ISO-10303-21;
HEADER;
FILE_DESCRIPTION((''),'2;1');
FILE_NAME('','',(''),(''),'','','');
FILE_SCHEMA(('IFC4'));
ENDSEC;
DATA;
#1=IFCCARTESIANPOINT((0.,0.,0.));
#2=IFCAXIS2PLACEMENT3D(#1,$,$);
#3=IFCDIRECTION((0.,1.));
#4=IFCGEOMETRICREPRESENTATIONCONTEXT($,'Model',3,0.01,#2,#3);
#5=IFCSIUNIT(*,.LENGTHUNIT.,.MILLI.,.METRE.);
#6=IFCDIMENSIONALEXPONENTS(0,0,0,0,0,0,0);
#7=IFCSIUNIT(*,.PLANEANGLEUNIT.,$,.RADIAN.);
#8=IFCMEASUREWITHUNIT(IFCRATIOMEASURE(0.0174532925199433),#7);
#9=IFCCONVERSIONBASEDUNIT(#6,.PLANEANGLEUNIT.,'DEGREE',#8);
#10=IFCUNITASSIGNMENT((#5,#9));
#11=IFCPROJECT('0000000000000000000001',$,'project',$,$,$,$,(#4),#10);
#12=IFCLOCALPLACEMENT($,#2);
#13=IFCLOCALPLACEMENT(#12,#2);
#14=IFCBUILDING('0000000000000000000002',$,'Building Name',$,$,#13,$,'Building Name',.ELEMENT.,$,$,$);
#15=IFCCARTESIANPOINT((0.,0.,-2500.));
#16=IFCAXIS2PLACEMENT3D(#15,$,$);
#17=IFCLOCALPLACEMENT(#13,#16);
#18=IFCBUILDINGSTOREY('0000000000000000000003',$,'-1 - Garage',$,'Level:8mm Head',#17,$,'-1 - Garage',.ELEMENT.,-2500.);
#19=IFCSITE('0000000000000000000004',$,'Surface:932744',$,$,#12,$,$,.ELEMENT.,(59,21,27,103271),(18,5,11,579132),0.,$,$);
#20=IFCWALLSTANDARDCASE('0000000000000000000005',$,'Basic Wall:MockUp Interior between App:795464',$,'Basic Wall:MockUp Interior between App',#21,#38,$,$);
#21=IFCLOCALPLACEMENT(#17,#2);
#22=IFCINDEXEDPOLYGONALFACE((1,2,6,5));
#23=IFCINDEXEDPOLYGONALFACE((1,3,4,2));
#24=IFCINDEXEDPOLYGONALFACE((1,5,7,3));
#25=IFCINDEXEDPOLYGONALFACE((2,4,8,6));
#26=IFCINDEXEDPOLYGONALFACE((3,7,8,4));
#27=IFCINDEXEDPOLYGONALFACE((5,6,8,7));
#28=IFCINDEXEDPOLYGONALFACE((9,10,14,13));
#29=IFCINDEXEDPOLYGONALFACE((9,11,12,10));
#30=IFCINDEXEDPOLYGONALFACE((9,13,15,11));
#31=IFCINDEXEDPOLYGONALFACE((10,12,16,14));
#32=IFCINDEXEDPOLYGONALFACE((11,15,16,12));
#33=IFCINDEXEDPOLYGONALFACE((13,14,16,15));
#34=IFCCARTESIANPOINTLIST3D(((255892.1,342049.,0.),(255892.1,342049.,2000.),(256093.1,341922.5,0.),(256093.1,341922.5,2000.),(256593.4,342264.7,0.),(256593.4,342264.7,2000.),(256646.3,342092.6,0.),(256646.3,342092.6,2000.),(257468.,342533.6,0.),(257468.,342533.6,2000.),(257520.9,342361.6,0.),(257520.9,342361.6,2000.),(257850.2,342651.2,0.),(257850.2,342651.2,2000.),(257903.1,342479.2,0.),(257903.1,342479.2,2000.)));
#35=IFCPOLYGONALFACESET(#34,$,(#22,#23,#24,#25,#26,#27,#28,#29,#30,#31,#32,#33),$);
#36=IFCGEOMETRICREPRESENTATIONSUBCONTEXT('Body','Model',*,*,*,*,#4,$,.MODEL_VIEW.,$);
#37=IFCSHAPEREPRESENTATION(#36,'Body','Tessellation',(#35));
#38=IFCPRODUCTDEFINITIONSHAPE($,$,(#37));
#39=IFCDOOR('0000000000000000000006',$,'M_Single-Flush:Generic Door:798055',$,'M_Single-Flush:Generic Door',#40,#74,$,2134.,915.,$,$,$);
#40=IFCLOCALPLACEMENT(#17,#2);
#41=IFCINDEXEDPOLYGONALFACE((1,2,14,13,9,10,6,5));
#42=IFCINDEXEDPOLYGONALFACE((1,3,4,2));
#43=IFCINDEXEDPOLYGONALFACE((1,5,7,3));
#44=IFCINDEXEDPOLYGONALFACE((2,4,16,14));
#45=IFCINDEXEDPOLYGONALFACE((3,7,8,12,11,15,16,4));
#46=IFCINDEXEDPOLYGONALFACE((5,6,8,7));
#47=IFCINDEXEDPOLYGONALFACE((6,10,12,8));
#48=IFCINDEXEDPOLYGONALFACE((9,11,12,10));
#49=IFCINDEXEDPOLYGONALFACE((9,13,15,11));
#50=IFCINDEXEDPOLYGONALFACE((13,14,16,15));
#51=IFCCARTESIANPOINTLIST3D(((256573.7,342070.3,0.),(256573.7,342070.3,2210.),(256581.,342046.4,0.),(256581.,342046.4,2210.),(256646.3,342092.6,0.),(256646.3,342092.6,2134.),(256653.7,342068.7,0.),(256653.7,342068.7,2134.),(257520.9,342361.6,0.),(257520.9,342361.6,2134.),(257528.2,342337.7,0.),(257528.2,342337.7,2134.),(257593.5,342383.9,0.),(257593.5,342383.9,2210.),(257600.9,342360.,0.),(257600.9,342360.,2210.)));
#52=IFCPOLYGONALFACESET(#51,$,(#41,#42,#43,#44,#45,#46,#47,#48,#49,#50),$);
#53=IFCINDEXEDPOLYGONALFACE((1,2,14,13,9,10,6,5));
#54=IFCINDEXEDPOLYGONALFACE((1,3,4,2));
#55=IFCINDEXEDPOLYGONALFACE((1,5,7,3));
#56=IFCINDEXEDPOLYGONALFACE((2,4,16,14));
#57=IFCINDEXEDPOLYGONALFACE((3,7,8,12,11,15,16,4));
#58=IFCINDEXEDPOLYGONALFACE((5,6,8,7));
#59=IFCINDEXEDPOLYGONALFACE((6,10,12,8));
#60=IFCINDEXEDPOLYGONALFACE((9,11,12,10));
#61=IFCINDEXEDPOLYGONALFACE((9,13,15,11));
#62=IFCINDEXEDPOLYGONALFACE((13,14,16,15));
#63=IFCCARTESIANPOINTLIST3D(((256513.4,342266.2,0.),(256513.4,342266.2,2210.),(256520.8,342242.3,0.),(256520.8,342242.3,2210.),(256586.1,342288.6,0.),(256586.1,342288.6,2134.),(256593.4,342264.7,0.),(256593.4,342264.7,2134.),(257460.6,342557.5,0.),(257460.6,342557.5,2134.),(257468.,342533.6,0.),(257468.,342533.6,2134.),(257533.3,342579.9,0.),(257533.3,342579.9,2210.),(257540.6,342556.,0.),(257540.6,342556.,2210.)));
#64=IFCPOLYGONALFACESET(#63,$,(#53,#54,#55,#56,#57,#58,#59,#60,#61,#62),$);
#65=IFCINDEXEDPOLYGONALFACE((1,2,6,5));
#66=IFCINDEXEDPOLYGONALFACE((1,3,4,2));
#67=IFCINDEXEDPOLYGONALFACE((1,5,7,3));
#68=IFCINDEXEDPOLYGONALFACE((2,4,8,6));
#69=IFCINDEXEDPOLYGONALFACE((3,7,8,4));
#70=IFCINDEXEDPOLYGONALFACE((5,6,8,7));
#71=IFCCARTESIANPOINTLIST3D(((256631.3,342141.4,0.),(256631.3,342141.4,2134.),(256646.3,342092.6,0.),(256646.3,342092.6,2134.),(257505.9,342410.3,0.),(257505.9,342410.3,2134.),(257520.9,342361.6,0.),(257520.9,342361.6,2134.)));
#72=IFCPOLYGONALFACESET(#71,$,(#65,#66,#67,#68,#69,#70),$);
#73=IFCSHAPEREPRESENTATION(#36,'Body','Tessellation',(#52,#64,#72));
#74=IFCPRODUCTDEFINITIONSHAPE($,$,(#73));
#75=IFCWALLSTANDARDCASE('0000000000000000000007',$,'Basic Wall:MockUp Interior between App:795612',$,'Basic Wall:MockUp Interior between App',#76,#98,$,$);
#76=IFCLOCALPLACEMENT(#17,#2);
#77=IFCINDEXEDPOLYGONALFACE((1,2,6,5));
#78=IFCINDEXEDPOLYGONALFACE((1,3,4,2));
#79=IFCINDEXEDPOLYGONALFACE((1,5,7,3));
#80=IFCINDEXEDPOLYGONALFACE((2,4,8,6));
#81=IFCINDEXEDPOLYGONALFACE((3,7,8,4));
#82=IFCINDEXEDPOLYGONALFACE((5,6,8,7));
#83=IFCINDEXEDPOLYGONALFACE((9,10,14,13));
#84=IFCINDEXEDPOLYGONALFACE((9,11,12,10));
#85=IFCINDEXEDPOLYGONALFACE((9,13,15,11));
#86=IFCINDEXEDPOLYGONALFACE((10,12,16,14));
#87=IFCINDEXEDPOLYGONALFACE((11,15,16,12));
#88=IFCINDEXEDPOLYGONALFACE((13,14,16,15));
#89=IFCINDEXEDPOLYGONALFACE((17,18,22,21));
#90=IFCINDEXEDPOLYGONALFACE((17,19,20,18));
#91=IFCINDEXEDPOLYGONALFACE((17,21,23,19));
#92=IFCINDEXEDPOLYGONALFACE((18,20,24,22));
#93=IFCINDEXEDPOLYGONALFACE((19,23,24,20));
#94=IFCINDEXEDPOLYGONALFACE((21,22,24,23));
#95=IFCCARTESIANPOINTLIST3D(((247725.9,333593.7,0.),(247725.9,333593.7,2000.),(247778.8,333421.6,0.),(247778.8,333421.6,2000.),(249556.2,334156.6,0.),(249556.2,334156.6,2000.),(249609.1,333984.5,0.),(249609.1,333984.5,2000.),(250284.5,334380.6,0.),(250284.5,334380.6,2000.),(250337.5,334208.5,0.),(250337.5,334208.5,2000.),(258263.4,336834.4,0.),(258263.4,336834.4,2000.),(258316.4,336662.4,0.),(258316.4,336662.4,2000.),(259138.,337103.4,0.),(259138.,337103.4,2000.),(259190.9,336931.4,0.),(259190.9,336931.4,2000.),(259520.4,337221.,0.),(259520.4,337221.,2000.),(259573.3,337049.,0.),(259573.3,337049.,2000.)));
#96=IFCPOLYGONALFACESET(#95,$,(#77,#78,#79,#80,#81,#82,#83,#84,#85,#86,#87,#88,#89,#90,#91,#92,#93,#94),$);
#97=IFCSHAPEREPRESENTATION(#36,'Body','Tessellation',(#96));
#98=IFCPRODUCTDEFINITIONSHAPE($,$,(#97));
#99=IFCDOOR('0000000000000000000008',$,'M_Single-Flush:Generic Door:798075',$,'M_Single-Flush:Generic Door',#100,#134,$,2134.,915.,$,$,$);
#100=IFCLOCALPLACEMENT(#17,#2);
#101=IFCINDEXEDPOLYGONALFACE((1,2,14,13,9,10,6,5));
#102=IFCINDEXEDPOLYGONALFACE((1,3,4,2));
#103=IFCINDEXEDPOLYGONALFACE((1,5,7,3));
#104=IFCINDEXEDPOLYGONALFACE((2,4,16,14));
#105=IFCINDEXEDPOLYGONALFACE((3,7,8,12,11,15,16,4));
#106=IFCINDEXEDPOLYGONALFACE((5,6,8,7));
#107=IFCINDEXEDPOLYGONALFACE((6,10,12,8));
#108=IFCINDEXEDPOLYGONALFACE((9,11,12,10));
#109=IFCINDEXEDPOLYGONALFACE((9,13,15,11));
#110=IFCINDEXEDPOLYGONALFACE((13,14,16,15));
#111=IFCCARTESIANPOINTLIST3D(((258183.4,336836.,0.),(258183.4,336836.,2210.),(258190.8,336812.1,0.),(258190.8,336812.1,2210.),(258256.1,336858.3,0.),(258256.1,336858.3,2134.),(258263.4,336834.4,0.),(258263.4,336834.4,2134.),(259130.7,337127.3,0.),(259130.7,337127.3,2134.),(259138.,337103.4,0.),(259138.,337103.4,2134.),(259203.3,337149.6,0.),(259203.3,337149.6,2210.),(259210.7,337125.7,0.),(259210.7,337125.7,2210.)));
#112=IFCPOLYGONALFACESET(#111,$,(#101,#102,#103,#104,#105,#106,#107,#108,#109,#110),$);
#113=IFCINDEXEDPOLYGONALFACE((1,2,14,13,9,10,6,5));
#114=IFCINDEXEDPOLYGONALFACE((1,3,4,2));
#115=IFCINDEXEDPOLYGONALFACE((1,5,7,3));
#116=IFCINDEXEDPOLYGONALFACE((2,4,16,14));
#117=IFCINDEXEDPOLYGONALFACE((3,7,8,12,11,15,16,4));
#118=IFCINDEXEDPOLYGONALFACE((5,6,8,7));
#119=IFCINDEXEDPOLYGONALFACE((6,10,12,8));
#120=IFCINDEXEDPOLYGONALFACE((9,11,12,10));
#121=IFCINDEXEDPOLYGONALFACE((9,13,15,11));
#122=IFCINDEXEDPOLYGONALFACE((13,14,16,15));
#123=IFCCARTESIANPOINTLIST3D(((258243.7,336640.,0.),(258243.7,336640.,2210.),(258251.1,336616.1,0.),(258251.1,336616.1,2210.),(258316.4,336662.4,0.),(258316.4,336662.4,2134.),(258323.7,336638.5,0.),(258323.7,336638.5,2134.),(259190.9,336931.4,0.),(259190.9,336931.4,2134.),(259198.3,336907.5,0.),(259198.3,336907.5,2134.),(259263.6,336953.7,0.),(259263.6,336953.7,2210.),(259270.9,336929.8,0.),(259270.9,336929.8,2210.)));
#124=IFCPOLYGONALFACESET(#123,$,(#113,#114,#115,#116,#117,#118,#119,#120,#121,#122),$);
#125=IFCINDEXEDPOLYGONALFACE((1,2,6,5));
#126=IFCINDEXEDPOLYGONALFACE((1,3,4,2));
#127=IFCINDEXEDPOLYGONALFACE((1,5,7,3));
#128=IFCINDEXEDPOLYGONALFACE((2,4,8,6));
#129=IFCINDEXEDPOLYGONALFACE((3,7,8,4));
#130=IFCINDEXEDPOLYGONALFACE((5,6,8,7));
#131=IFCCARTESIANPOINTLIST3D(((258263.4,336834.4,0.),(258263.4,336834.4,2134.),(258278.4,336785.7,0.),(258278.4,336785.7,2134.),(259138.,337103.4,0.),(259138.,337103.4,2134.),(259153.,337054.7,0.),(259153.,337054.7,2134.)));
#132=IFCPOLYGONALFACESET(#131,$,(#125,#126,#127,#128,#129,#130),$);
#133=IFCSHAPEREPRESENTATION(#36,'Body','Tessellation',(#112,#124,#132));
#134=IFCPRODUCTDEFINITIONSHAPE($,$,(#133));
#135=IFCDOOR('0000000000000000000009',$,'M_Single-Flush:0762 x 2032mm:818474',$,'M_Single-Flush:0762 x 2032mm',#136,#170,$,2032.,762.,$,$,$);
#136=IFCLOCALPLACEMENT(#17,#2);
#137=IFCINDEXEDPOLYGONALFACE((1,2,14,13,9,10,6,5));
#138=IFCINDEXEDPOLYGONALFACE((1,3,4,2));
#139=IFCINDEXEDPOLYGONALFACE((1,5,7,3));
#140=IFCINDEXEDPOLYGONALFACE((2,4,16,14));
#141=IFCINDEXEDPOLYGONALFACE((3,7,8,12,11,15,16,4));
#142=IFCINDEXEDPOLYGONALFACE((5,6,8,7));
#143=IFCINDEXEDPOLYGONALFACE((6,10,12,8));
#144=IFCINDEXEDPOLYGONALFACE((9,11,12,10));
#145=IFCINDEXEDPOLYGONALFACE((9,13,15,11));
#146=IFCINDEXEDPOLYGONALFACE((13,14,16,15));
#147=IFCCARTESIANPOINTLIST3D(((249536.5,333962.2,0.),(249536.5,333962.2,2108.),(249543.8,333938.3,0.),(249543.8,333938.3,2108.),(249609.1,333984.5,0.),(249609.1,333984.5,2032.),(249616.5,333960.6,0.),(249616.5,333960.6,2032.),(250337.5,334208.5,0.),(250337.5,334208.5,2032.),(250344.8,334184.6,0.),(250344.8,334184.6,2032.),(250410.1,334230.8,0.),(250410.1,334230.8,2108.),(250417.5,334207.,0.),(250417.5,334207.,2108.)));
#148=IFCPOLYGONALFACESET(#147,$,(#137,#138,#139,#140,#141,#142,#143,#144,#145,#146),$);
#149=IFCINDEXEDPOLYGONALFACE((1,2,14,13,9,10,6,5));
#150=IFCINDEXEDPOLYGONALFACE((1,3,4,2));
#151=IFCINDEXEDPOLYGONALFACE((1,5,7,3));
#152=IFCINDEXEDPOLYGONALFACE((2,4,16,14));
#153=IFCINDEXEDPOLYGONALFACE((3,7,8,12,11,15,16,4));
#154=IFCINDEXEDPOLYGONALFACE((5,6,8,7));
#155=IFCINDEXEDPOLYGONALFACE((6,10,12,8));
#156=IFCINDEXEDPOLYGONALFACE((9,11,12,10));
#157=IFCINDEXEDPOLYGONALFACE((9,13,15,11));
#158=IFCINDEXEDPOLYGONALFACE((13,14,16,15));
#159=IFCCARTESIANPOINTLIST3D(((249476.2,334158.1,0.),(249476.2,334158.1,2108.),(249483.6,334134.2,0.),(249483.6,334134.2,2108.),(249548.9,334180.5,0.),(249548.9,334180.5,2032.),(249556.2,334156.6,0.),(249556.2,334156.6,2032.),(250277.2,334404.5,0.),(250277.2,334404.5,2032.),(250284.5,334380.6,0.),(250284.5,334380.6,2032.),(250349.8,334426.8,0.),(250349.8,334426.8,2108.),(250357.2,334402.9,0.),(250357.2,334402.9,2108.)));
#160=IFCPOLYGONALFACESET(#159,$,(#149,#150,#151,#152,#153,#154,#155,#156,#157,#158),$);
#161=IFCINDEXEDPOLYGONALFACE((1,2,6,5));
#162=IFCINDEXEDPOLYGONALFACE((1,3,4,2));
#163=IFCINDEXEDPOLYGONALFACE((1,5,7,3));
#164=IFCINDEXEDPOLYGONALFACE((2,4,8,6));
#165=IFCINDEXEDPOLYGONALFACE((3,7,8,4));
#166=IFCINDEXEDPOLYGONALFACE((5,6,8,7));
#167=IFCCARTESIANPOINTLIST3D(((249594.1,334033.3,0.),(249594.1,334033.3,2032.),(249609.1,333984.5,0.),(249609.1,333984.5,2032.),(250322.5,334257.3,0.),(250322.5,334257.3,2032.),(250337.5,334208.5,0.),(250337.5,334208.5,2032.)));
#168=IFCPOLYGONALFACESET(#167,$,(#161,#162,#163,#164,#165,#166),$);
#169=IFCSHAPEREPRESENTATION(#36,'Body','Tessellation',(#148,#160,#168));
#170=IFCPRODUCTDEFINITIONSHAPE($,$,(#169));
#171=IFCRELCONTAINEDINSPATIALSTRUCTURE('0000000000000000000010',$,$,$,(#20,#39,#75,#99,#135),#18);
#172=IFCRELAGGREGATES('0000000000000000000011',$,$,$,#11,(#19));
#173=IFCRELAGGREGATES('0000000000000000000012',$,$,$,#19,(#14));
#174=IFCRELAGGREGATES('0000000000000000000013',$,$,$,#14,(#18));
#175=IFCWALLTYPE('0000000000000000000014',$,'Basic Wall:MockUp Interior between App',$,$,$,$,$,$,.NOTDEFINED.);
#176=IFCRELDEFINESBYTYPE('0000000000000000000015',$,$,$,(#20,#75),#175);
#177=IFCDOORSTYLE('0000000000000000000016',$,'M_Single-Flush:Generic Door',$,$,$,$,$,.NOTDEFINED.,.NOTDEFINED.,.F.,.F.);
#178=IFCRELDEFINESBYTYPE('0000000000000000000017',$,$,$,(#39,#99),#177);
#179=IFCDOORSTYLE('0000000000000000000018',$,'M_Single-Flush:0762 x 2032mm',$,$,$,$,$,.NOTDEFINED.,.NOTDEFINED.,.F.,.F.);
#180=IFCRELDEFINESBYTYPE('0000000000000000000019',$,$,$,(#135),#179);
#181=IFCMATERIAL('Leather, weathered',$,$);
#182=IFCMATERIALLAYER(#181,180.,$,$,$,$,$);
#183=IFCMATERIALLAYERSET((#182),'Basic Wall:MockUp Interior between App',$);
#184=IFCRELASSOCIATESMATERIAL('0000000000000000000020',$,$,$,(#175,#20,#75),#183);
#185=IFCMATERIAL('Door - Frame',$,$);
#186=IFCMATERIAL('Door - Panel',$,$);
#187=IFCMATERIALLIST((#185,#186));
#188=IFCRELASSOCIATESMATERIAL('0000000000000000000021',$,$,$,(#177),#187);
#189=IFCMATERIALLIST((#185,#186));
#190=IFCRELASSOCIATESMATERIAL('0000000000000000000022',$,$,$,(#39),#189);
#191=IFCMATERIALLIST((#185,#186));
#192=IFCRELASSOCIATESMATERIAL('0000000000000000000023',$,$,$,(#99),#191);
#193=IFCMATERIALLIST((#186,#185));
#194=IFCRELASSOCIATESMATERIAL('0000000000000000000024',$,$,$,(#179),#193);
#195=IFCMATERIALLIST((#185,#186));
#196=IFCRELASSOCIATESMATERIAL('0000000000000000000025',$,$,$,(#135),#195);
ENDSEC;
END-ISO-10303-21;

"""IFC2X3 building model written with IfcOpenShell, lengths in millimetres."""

from ifc_helpers import new_model, entity, si_unit, converted_unit, direction, frame, frame_2d, origin, place, context, subcontext, project, spatial, polyline, rectangle, outline, extrude, source, transform, mapped, material, material_list, layer, layer_set, layer_usage, type_object, type_shapes, element, fill, save


model = new_model("IFC2X3")

# Units and contexts
model_context = context("Model", 3, precision=0.01, world=origin(), true_north=direction((0.0, 1.0)))
body_context = subcontext(model_context, "Body", "Model", "MODEL_VIEW")
ifc_project = project(units=[si_unit("LENGTHUNIT", "METRE", prefix="MILLI"), converted_unit("PLANEANGLEUNIT", "DEGREE", entity("IfcRatioMeasure", 0.0174532925199433), si_unit("PLANEANGLEUNIT", "RADIAN"), dimensions=[0, 0, 0, 0, 0, 0, 0])], contexts=[model_context])

# Site, building, storey
site_placement = place(None, origin())
site = spatial("IfcSite", under=ifc_project, at=site_placement, Name="Surface:932744", CompositionType="ELEMENT", RefLatitude=(59, 21, 27, 103271), RefLongitude=(18, 5, 11, 579132), RefElevation=0.0)
building_placement = place(site_placement, origin())
building = spatial("IfcBuilding", under=site, at=building_placement, Name="Building Name", LongName="Building Name", CompositionType="ELEMENT")
storey_placement = place(building_placement, frame((0.0, 0.0, -2500.0)))
storey = spatial("IfcBuildingStorey", under=building, at=storey_placement, Name="-1 - Garage", ObjectType="Level:8mm Head", LongName="-1 - Garage", CompositionType="ELEMENT", Elevation=-2500.0)

# Wall, opening, door
ifc_material_1 = material(Name="Leather, weathered")
ifc_layer_1 = layer(ifc_material_1, 180.0)
ifc_layer_set_1 = layer_set([ifc_layer_1], Name="Basic Wall:MockUp Interior between App")
ifc_layer_usage_1 = layer_usage(ifc_layer_set_1, "AXIS2", "NEGATIVE", 90.0)
wall_type_1 = type_object("IfcWallType", Name="Basic Wall:MockUp Interior between App", PredefinedType="NOTDEFINED", material=ifc_layer_set_1)
wall_1_placement = place(storey_placement, frame((257876.7, 342565.2, 0.0), z_axis=(0.0, 0.0, 1.0), x_axis=(-0.955818, -0.293958, 0.0)))
wall_1 = element("IfcWallStandardCase", 1, at=wall_1_placement, inside=storey, type_object=wall_type_1, material=ifc_layer_usage_1, Name="Basic Wall:MockUp Interior between App:795464", ObjectType="Basic Wall:MockUp Interior between App", context=body_context, shape_type="SweptSolid", body=[
    extrude(outline(polyline([(0.0, 90.0), (0.0, -90.0), (2048.7, -90.0), (1893.7, 90.0), (0.0, 90.0)])), origin(), (0.0, 0.0, 1.0), 2000.0),
])
opening_1_placement = place(wall_1_placement, frame((399.9, -90.0, 0.0)))
opening_1 = element("IfcOpeningElement", 2, at=opening_1_placement, cuts=wall_1, ObjectType="Opening", context=body_context, shape_type="SweptSolid", body=[
    extrude(rectangle(XDim=915.0, YDim=2134.0, at=frame_2d((1067.0, 457.5), x_axis=(0.0, 1.0))), frame((0.0, 0.0, 0.0), z_axis=(0.0, 1.0, 0.0), x_axis=(0.0, 0.0, 1.0)), (0.0, 0.0, 1.0), 180.0),
])
ifc_material_2 = material(Name="Door - Frame")
ifc_material_3 = material(Name="Door - Panel")
ifc_material_list_1 = material_list([ifc_material_2, ifc_material_3])
ifc_material_list_2 = material_list([ifc_material_2, ifc_material_3])
door_style_1 = type_object("IfcDoorStyle", Name="M_Single-Flush:Generic Door", ConstructionType="NOTDEFINED", OperationType="NOTDEFINED", ParameterTakesPrecedence=False, Sizeable=False, material=ifc_material_list_2)
shared_shape_1 = source(origin(), body_context, "Body", "SweptSolid", [
    extrude(outline(polyline([(-533.5, -1124.0), (533.5, -1124.0), (533.5, 1086.0), (457.5, 1086.0), (457.5, -1048.0), (-457.5, -1048.0), (-457.5, 1086.0), (-533.5, 1086.0), (-533.5, -1124.0)])), frame((457.5, 180.0, 1086.0), z_axis=(0.0, 1.0, 0.0), x_axis=(1.0, 0.0, 0.0)), (0.0, 0.0, 1.0), 25.0),
    extrude(outline(polyline([(-1124.0, -533.5), (1086.0, -533.5), (1086.0, -457.5), (-1048.0, -457.5), (-1048.0, 457.5), (1086.0, 457.5), (1086.0, 533.5), (-1124.0, 533.5), (-1124.0, -533.5)])), frame((457.5, -25.0, 1086.0), z_axis=(0.0, 1.0, 0.0), x_axis=(0.0, 0.0, -1.0)), (0.0, 0.0, 1.0), 25.0),
    extrude(rectangle(XDim=51.0, YDim=915.0, at=frame_2d((0.0, 0.0), x_axis=(1.0, 0.0))), frame((457.5, 154.5, 0.0), z_axis=(0.0, 0.0, 1.0), x_axis=(0.0, 1.0, 0.0)), (0.0, 0.0, 1.0), 2134.0),
])
type_shapes(door_style_1, [shared_shape_1])
door_1_placement = place(opening_1_placement, origin())
door_1 = element("IfcDoor", 3, at=door_1_placement, inside=storey, type_object=door_style_1, material=ifc_material_list_1, Name="M_Single-Flush:Generic Door:798055", ObjectType="M_Single-Flush:Generic Door", OverallHeight=2134.0, OverallWidth=915.0, context=body_context, shape_type="MappedRepresentation", body=[
    mapped(shared_shape_1, transform((0.0, 0.0, 0.0), scale=1.0)),
])
fill(opening_1, door_1)

# Wall, openings, doors
ifc_layer_usage_2 = layer_usage(ifc_layer_set_1, "AXIS2", "NEGATIVE", 90.0)
wall_2_placement = place(storey_placement, frame((259546.9, 337135.0, 0.0), z_axis=(0.0, 0.0, 1.0), x_axis=(-0.955818, -0.293958, 0.0)))
wall_2 = element("IfcWallStandardCase", 4, at=wall_2_placement, inside=storey, type_object=wall_type_1, material=ifc_layer_usage_2, Name="Basic Wall:MockUp Interior between App:795612", ObjectType="Basic Wall:MockUp Interior between App", context=body_context, shape_type="SweptSolid", body=[
    extrude(rectangle(XDim=12339.7, YDim=180.0, at=frame_2d((6169.8, 0.0), x_axis=(-1.0, 0.0))), origin(), (0.0, 0.0, 1.0), 2000.0),
])
opening_2_placement = place(wall_2_placement, frame((1315.1, 90.0, 0.0)))
opening_2 = element("IfcOpeningElement", 5, at=opening_2_placement, cuts=wall_2, ObjectType="Opening", context=body_context, shape_type="SweptSolid", body=[
    extrude(rectangle(XDim=915.0, YDim=2134.0, at=frame_2d((1067.0, 457.5), x_axis=(0.0, 1.0))), frame((0.0, 0.0, 0.0), z_axis=(0.0, -1.0, 0.0), x_axis=(0.0, 0.0, 1.0)), (0.0, 0.0, 1.0), 180.0),
])
opening_3_placement = place(wall_2_placement, frame((9662.8, -90.0, 0.0)))
opening_3 = element("IfcOpeningElement", 6, at=opening_3_placement, cuts=wall_2, ObjectType="Opening", context=body_context, shape_type="SweptSolid", body=[
    extrude(rectangle(XDim=762.0, YDim=2032.0, at=frame_2d((1016.0, 381.0), x_axis=(0.0, 1.0))), frame((0.0, 0.0, 0.0), z_axis=(0.0, 1.0, 0.0), x_axis=(0.0, 0.0, 1.0)), (0.0, 0.0, 1.0), 180.0),
])
ifc_material_list_3 = material_list([ifc_material_2, ifc_material_3])
door_2_placement = place(opening_2_placement, frame((0.0, 0.0, 0.0), z_axis=(0.0, 0.0, 1.0), x_axis=(-1.0, 0.0, 0.0)))
door_2 = element("IfcDoor", 7, at=door_2_placement, inside=storey, type_object=door_style_1, material=ifc_material_list_3, Name="M_Single-Flush:Generic Door:798075", ObjectType="M_Single-Flush:Generic Door", OverallHeight=2134.0, OverallWidth=915.0, context=body_context, shape_type="MappedRepresentation", body=[
    mapped(shared_shape_1, transform((0.0, 0.0, 0.0), scale=1.0)),
])
fill(opening_2, door_2)
ifc_material_list_4 = material_list([ifc_material_2, ifc_material_3])
ifc_material_list_5 = material_list([ifc_material_3, ifc_material_2])
door_style_2 = type_object("IfcDoorStyle", Name="M_Single-Flush:0762 x 2032mm", ConstructionType="NOTDEFINED", OperationType="NOTDEFINED", ParameterTakesPrecedence=False, Sizeable=False, material=ifc_material_list_5)
shared_shape_2 = source(origin(), body_context, "Body", "SweptSolid", [
    extrude(outline(polyline([(-457.0, -1073.0), (457.0, -1073.0), (457.0, 1035.0), (381.0, 1035.0), (381.0, -997.0), (-381.0, -997.0), (-381.0, 1035.0), (-457.0, 1035.0), (-457.0, -1073.0)])), frame((381.0, 180.0, 1035.0), z_axis=(0.0, 1.0, 0.0), x_axis=(1.0, 0.0, 0.0)), (0.0, 0.0, 1.0), 25.0),
    extrude(outline(polyline([(-1073.0, -457.0), (1035.0, -457.0), (1035.0, -381.0), (-997.0, -381.0), (-997.0, 381.0), (1035.0, 381.0), (1035.0, 457.0), (-1073.0, 457.0), (-1073.0, -457.0)])), frame((381.0, -25.0, 1035.0), z_axis=(0.0, 1.0, 0.0), x_axis=(0.0, 0.0, -1.0)), (0.0, 0.0, 1.0), 25.0),
    extrude(rectangle(XDim=51.0, YDim=762.0, at=frame_2d((0.0, 0.0), x_axis=(1.0, 0.0))), frame((381.0, 154.5, 0.0), z_axis=(0.0, 0.0, 1.0), x_axis=(0.0, 1.0, 0.0)), (0.0, 0.0, 1.0), 2032.0),
])
type_shapes(door_style_2, [shared_shape_2])
door_3_placement = place(opening_3_placement, origin())
door_3 = element("IfcDoor", 8, at=door_3_placement, inside=storey, type_object=door_style_2, material=ifc_material_list_4, Name="M_Single-Flush:0762 x 2032mm:818474", ObjectType="M_Single-Flush:0762 x 2032mm", OverallHeight=2032.0, OverallWidth=762.0, context=body_context, shape_type="MappedRepresentation", body=[
    mapped(shared_shape_2, transform((0.0, 0.0, 0.0), scale=1.0)),
])
fill(opening_3, door_3)

save(model, "model.ifc")
